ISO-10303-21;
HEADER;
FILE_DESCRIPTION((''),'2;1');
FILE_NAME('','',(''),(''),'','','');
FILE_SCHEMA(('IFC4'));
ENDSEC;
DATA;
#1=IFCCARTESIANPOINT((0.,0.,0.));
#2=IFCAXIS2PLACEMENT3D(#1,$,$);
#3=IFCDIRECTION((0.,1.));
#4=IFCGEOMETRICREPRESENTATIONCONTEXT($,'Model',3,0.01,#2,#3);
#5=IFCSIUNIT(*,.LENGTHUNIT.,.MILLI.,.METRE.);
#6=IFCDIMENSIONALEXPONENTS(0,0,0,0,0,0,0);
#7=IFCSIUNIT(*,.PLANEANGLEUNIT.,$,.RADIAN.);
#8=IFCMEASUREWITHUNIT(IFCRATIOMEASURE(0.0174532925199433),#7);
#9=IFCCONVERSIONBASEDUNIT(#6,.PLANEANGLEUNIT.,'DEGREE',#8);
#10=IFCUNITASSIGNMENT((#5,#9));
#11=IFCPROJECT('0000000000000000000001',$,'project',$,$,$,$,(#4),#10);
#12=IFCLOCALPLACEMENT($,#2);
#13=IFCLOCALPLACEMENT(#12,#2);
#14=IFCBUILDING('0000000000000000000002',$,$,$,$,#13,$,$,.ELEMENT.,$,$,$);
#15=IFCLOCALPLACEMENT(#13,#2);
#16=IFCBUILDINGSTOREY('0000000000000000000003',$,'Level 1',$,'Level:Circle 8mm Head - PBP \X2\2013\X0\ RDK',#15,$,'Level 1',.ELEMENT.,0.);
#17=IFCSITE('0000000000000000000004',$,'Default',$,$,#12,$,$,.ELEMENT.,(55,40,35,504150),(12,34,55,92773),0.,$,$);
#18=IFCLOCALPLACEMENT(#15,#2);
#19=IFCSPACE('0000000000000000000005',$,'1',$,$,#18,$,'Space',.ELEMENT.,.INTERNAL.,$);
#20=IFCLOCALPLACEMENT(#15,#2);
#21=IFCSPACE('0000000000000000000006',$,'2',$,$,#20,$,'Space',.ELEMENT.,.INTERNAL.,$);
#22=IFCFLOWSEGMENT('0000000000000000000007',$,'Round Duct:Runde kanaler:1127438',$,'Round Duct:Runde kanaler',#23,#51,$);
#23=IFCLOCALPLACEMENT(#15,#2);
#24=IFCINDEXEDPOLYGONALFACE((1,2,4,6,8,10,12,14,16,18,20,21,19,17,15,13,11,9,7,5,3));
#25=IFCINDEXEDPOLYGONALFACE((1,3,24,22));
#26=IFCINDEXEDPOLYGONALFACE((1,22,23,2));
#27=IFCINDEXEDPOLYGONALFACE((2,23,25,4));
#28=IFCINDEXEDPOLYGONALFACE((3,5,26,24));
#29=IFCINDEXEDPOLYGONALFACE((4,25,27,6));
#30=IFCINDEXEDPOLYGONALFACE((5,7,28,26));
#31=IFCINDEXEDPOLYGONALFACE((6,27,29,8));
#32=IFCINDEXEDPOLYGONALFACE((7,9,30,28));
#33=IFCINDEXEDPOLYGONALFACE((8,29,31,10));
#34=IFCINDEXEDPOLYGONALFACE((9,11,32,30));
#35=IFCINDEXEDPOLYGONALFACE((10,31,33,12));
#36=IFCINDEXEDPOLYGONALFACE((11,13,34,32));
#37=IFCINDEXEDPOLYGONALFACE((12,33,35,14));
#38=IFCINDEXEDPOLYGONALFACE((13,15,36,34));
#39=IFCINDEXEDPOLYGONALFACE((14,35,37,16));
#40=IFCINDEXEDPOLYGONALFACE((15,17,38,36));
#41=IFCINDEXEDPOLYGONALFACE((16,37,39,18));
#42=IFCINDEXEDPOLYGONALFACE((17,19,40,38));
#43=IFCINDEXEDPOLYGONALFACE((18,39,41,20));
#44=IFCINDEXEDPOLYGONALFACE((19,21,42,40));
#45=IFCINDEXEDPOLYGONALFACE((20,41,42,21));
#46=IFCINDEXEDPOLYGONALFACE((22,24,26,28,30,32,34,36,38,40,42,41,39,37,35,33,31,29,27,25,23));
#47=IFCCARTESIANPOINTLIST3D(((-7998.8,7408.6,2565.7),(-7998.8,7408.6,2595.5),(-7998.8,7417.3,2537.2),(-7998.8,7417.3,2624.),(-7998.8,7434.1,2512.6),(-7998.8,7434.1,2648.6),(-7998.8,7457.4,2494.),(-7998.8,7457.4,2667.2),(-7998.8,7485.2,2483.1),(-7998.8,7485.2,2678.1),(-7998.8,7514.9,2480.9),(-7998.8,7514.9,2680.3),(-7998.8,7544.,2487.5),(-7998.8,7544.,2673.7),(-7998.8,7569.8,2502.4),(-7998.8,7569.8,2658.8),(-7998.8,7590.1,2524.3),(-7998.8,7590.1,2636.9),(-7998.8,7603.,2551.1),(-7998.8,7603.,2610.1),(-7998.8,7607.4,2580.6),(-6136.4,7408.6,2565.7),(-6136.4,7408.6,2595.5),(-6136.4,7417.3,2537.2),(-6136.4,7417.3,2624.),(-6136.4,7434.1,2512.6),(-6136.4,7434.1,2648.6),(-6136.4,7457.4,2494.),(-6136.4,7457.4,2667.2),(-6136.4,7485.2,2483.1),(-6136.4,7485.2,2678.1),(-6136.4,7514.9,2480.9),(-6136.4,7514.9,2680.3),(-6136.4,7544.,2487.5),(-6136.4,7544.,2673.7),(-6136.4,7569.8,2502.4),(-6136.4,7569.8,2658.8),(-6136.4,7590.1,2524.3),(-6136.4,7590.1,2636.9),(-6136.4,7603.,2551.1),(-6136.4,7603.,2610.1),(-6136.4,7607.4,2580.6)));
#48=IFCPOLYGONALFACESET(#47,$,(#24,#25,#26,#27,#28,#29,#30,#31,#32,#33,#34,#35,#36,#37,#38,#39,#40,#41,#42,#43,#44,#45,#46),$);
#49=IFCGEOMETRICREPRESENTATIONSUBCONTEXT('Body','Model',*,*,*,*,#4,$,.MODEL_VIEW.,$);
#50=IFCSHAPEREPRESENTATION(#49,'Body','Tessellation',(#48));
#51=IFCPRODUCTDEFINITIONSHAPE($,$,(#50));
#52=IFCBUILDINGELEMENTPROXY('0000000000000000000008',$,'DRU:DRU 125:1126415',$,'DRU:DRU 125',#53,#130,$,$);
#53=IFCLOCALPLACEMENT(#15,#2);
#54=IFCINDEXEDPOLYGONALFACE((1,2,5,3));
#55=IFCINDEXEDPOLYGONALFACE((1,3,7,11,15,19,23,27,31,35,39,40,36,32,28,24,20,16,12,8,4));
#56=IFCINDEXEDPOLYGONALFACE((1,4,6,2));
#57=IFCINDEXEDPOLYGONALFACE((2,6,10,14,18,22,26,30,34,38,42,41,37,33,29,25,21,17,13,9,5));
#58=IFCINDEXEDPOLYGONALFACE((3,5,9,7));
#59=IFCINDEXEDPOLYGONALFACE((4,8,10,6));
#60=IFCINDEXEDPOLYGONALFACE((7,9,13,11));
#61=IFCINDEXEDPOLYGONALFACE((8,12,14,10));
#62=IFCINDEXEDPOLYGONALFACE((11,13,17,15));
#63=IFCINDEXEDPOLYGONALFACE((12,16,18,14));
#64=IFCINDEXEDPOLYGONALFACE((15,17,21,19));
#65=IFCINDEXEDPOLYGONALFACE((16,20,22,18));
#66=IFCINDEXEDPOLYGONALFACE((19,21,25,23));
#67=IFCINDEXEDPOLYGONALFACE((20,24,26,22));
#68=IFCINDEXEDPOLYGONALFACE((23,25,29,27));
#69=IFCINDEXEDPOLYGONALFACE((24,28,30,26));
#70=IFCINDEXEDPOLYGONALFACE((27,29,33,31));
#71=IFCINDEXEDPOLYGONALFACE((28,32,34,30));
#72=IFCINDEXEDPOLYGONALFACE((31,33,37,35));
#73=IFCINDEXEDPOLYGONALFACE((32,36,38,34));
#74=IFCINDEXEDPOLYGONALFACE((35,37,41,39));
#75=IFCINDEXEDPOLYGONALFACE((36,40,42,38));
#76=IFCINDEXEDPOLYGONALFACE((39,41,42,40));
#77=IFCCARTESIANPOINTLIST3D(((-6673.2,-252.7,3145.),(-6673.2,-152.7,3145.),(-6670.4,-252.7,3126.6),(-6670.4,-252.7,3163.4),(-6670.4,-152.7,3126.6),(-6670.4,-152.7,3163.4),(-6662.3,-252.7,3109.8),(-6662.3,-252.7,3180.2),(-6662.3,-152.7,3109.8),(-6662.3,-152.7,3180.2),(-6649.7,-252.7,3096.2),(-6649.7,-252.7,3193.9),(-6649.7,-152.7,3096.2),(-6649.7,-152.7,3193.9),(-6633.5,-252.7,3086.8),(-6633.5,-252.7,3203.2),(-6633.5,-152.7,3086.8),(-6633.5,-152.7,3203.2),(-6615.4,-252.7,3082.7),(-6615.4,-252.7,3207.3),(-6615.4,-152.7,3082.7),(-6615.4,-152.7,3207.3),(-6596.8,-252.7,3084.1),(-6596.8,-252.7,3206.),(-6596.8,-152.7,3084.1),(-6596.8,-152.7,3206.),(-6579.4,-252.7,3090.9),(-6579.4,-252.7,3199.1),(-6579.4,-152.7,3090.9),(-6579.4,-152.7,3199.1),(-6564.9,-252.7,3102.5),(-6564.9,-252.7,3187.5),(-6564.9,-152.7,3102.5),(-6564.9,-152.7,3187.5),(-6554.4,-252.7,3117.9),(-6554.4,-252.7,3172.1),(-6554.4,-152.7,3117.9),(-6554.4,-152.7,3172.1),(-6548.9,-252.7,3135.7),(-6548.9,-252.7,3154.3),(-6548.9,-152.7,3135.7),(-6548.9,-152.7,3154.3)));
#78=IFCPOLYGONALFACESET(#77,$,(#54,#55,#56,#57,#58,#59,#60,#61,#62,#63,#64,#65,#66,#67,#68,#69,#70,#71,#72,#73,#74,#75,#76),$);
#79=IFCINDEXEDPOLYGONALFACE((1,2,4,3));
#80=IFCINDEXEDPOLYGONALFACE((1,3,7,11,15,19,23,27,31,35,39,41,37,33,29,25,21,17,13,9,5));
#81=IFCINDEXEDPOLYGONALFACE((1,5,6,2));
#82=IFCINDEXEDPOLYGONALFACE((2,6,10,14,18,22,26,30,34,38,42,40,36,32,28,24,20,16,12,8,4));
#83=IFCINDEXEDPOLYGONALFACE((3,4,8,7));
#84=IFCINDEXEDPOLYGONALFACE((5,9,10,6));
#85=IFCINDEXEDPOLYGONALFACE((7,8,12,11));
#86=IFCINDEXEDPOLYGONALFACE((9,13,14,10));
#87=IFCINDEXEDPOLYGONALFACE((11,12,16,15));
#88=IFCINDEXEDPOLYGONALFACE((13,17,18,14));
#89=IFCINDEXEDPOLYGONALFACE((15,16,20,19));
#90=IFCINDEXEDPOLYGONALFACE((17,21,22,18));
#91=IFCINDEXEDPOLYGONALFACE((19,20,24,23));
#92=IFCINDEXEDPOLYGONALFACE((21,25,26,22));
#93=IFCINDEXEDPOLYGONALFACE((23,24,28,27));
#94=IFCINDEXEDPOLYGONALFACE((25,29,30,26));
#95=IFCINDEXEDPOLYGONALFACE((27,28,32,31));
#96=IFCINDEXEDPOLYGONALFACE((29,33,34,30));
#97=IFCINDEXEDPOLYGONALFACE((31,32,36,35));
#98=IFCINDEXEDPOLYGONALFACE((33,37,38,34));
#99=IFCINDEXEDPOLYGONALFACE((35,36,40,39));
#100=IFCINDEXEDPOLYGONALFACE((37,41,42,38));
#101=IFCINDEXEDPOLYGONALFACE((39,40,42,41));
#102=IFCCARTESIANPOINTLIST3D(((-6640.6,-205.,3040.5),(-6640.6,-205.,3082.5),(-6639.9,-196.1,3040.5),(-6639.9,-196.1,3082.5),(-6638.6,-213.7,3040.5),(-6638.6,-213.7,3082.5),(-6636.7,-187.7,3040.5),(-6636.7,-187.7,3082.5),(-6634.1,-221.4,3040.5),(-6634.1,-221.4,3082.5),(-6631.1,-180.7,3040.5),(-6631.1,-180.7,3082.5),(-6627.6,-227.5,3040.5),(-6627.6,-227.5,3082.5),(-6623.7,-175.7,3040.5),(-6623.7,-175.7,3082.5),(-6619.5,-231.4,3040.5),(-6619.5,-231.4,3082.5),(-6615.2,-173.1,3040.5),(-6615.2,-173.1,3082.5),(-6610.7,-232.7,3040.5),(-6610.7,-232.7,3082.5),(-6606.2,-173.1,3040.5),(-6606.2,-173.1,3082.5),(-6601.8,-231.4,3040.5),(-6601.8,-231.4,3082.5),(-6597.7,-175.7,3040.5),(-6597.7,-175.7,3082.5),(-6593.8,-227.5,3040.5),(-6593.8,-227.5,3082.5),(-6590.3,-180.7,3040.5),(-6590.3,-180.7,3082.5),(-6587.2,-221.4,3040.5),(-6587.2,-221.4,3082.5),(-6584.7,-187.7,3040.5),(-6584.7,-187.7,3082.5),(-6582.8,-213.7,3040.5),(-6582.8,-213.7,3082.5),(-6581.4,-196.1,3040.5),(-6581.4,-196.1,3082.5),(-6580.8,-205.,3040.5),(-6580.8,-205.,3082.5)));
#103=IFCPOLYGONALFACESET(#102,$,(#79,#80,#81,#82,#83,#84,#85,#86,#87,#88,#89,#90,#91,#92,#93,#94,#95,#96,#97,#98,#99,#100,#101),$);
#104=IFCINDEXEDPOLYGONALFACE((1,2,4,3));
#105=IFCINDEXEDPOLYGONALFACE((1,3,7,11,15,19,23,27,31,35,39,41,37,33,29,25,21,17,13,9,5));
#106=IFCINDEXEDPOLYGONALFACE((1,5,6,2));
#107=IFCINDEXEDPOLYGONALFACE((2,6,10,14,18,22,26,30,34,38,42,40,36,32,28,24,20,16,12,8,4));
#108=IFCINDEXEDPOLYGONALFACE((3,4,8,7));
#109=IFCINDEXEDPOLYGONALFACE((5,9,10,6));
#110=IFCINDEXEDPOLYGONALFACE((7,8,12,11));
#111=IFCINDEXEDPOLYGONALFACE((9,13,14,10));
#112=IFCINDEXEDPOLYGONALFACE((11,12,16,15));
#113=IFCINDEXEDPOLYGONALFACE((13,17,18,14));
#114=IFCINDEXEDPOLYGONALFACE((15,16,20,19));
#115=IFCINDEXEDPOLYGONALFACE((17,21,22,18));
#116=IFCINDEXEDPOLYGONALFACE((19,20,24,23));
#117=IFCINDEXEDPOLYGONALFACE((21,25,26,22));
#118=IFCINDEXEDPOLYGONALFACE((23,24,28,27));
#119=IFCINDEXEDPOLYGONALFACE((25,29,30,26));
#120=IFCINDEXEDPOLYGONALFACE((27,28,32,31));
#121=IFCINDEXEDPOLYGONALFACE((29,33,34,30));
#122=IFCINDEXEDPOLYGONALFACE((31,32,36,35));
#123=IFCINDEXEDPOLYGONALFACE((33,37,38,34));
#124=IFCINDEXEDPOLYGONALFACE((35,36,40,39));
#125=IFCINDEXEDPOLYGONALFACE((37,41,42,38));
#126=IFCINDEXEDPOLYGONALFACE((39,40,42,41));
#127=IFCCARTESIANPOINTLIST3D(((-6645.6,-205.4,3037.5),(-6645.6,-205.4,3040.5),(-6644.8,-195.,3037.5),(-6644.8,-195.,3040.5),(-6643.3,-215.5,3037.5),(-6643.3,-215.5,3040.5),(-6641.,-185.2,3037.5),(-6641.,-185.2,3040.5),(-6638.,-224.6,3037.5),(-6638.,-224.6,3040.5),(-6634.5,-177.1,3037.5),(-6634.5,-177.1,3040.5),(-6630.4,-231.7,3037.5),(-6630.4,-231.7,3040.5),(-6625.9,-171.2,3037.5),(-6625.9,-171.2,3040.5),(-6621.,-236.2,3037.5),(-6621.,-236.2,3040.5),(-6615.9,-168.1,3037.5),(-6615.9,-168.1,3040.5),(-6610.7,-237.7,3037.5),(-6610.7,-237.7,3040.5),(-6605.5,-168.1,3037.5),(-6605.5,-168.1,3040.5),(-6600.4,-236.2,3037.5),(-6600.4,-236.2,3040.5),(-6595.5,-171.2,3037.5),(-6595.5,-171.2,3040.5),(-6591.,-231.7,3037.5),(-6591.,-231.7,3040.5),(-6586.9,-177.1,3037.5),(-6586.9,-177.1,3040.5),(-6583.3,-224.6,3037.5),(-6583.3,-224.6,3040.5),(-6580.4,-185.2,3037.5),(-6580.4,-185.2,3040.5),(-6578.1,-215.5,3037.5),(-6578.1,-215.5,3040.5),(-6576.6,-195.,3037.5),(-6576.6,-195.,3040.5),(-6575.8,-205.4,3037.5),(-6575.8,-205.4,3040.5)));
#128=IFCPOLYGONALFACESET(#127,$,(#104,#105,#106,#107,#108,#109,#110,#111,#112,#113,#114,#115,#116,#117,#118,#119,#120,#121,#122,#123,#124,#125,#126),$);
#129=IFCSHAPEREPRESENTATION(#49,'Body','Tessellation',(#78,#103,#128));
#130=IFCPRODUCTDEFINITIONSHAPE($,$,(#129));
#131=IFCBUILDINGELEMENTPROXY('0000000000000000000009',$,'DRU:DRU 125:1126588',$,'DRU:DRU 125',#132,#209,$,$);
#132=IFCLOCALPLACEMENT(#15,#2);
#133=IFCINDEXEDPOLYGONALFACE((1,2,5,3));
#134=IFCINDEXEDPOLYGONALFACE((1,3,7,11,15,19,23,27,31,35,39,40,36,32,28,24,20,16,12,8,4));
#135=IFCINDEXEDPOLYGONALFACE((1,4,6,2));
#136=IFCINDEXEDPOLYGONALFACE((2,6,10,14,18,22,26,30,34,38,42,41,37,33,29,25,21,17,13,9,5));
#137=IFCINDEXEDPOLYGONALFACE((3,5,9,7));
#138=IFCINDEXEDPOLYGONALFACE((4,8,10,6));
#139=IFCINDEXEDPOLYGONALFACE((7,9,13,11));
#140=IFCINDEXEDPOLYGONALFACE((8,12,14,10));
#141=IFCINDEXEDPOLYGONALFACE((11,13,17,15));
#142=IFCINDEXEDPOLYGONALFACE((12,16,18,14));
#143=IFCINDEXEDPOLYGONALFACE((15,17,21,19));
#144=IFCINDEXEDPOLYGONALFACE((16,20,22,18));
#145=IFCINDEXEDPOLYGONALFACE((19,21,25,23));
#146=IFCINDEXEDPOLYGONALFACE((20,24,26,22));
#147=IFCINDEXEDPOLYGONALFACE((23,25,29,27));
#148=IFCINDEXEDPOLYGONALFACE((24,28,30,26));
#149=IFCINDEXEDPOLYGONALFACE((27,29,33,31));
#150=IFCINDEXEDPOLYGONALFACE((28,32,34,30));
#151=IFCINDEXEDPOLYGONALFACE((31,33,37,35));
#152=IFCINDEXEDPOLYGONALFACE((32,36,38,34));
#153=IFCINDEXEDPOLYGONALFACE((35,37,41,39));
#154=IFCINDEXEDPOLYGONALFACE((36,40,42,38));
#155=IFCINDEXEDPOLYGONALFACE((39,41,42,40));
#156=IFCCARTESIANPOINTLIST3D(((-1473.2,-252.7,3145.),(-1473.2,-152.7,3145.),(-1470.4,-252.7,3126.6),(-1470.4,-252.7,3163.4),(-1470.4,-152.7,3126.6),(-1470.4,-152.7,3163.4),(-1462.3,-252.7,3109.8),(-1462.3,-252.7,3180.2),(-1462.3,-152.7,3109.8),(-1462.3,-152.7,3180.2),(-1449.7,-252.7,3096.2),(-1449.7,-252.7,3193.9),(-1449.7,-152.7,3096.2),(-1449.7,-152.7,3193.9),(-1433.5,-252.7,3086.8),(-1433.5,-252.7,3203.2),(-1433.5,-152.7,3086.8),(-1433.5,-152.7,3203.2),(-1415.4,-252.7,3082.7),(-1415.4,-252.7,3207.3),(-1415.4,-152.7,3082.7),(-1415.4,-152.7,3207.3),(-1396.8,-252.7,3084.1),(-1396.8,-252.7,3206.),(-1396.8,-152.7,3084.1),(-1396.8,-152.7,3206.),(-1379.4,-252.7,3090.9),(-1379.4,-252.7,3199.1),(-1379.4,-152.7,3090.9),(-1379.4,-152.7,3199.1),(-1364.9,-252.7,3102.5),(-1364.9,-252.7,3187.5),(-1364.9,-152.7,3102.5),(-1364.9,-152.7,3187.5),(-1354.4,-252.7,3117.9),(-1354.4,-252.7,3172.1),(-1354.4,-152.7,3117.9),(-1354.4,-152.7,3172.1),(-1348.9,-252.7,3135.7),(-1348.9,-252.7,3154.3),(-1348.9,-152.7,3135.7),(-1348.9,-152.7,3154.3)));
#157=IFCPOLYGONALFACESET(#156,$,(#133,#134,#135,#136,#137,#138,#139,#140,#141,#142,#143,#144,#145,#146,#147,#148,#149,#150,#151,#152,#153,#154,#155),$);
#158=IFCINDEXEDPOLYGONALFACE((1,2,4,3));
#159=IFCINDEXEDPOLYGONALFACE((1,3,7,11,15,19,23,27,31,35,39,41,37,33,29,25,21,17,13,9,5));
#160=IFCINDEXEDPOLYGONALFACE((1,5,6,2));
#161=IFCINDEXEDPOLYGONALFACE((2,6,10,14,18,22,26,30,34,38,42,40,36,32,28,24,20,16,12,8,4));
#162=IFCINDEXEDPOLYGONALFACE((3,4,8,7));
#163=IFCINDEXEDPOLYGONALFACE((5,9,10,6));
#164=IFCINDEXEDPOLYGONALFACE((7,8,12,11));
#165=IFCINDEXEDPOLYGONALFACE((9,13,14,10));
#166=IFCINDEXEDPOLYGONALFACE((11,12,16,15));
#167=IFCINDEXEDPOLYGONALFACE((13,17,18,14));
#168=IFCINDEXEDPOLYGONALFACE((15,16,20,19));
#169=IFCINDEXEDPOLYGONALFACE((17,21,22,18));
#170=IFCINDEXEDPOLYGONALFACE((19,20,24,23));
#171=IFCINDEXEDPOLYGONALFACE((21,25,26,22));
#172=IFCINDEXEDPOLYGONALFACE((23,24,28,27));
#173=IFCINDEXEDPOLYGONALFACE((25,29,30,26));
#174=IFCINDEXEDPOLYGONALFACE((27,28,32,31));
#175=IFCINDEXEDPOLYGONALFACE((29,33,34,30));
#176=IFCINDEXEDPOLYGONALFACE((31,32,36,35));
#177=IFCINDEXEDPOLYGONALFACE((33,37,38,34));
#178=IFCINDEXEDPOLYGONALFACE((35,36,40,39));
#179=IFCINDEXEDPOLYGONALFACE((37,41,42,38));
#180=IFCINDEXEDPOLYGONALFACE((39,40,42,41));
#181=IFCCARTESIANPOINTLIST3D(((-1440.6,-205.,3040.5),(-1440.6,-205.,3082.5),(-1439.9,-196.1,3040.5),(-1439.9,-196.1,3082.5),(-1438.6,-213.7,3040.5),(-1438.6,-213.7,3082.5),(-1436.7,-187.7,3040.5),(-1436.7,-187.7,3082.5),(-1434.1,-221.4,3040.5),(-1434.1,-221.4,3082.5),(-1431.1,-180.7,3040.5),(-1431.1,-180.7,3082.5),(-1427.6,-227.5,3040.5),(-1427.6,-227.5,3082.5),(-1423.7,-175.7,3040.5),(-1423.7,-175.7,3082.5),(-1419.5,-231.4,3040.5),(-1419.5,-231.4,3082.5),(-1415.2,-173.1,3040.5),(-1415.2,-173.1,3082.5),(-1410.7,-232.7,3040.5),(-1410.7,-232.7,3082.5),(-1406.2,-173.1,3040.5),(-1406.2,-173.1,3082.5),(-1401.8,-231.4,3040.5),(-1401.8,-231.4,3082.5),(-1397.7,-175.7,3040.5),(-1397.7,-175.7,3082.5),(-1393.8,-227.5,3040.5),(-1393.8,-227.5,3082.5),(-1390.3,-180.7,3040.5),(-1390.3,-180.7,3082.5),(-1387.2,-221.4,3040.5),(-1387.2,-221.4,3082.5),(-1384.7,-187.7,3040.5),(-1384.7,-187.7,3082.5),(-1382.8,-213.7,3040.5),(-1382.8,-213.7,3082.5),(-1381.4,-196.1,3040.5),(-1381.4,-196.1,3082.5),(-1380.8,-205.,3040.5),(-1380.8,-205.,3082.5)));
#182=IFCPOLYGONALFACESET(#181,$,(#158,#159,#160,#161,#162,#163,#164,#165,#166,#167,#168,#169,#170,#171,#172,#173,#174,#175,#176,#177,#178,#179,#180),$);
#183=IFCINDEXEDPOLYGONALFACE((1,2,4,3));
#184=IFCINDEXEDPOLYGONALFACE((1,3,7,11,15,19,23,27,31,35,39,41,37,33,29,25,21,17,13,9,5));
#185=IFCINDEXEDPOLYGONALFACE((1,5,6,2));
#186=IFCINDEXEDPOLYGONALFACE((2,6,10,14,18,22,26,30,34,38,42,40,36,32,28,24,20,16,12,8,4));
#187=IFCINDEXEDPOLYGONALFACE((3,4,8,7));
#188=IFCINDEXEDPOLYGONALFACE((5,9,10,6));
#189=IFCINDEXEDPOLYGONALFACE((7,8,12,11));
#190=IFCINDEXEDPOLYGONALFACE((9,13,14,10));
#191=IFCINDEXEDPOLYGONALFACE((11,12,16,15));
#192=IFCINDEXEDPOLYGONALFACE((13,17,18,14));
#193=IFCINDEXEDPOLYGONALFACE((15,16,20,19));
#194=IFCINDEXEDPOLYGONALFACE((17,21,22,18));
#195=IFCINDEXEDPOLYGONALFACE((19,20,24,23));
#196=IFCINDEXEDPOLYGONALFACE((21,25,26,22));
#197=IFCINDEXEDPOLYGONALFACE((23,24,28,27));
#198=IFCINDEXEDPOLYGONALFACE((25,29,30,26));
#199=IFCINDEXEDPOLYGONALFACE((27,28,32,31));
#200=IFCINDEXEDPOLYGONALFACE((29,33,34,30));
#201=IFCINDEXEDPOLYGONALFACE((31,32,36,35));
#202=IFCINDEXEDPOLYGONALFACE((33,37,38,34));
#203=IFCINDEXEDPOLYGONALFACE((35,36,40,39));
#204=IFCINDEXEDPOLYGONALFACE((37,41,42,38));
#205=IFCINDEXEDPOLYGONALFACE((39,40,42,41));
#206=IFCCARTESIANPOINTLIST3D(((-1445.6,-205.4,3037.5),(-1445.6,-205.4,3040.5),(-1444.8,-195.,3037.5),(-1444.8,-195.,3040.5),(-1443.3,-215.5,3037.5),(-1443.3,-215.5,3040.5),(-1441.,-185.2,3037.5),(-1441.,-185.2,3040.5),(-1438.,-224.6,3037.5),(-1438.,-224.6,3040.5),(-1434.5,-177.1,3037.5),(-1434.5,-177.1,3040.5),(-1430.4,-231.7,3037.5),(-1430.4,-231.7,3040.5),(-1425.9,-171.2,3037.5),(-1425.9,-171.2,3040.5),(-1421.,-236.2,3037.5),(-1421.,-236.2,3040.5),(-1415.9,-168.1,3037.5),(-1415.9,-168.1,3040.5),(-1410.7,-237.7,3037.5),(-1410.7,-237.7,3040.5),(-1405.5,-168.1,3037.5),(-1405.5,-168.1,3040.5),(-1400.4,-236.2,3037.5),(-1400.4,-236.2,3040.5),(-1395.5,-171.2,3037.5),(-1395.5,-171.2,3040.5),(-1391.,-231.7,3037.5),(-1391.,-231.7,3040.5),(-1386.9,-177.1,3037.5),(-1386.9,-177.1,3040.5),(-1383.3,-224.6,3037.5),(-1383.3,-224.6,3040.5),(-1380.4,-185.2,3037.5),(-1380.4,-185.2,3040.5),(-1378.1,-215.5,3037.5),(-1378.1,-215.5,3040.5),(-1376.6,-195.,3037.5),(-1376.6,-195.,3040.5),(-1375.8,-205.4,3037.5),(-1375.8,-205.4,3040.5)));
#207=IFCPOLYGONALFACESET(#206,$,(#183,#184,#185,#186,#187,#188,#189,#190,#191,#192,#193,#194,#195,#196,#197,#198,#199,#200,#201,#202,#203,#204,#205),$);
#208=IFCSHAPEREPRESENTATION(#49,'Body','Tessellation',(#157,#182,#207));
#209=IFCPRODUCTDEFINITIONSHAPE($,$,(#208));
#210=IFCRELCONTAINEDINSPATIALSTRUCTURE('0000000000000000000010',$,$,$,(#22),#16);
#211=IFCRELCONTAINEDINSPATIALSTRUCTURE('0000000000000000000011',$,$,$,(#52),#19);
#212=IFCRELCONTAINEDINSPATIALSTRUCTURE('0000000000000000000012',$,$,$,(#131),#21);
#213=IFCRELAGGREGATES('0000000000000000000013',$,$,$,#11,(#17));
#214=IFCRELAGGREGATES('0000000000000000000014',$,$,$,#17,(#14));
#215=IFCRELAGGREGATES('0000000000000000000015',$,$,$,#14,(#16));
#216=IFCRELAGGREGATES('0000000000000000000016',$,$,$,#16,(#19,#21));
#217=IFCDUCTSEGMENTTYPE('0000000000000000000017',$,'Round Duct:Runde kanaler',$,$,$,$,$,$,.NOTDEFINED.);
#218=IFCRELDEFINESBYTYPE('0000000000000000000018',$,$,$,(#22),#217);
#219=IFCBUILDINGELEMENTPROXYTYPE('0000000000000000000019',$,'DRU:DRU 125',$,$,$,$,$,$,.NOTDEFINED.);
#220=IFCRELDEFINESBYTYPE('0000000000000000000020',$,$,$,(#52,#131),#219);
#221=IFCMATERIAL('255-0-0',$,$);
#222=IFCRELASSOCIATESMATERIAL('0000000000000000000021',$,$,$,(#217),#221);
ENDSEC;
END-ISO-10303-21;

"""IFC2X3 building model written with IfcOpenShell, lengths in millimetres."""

from ifc_helpers import new_model, entity, si_unit, converted_unit, direction, frame, frame_2d, origin, place, context, subcontext, project, spatial, circle, extrude, source, transform, mapped, material, type_object, type_shapes, element, save


model = new_model("IFC2X3")

# Units and contexts
model_context = context("Model", 3, precision=0.01, world=origin(), true_north=direction((0.0, 1.0)))
body_context = subcontext(model_context, "Body", "Model", "MODEL_VIEW")
ifc_project = project(units=[si_unit("LENGTHUNIT", "METRE", prefix="MILLI"), converted_unit("PLANEANGLEUNIT", "DEGREE", entity("IfcRatioMeasure", 0.0174532925199433), si_unit("PLANEANGLEUNIT", "RADIAN"), dimensions=[0, 0, 0, 0, 0, 0, 0])], contexts=[model_context])

# Site, building, storey
site_placement = place(None, origin())
site = spatial("IfcSite", under=ifc_project, at=site_placement, Name="Default", CompositionType="ELEMENT", RefLatitude=(55, 40, 35, 504150), RefLongitude=(12, 34, 55, 92773), RefElevation=0.0)
building_placement = place(site_placement, origin())
building = spatial("IfcBuilding", under=site, at=building_placement, CompositionType="ELEMENT")
storey_placement = place(building_placement, origin())
storey = spatial("IfcBuildingStorey", under=building, at=storey_placement, Name="Level 1", ObjectType="Level:Circle 8mm Head - PBP – RDK", LongName="Level 1", CompositionType="ELEMENT", Elevation=0.0)

# Flow segment
ifc_material_1 = material(Name="255-0-0")
duct_segment_type = type_object("IfcDuctSegmentType", Name="Round Duct:Runde kanaler", PredefinedType="NOTDEFINED", material=ifc_material_1)
flow_segment_1_placement = place(storey_placement, origin())
element("IfcFlowSegment", 1, at=flow_segment_1_placement, inside=storey, type_object=duct_segment_type, Name="Round Duct:Runde kanaler:1127438", ObjectType="Round Duct:Runde kanaler", context=body_context, shape_type="SweptSolid", body=[
    extrude(circle(Radius=100.0, at=frame_2d((0.0, 0.0), x_axis=(1.0, 0.0))), frame((-7998.8, 7507.4, 2580.6), z_axis=(1.0, 0.0, 0.0), x_axis=(0.0, 1.0, 0.0)), (0.0, 0.0, 1.0), 1862.4),
])

# Shared definitions
space_1_placement = place(storey_placement, origin())
space_1 = spatial("IfcSpace", under=storey, at=space_1_placement, Name="1", LongName="Space", CompositionType="ELEMENT", InteriorOrExteriorSpace="INTERNAL")

# Building element proxy
building_element_proxy_type_1 = type_object("IfcBuildingElementProxyType", Name="DRU:DRU 125", PredefinedType="NOTDEFINED")
shared_shape_1 = source(origin(), body_context, "Body", "SweptSolid", [
    extrude(circle(Radius=62.5, at=frame_2d((0.0, 0.0), x_axis=(1.0, 0.0))), frame((-50.0, 0.0, 0.0), z_axis=(1.0, 0.0, 0.0), x_axis=(0.0, 1.0, 0.0)), (0.0, 0.0, 1.0), 100.0),
    extrude(circle(Radius=30.0, at=frame_2d((0.0, 0.0), x_axis=(1.0, 0.0))), frame((0.0, 0.0, 62.5)), (0.0, 0.0, 1.0), 42.0),
    extrude(circle(Radius=35.0, at=frame_2d((0.0, 0.0), x_axis=(1.0, 0.0))), frame((0.0, 0.0, 104.5)), (0.0, 0.0, 1.0), 3.0),
])
type_shapes(building_element_proxy_type_1, [shared_shape_1])
proxy_1_placement = place(space_1_placement, frame((-6610.7, -202.7, 3145.0), z_axis=(0.0, 0.0, -1.0), x_axis=(0.0, -1.0, 0.0)))
element("IfcBuildingElementProxy", 2, at=proxy_1_placement, inside=space_1, type_object=building_element_proxy_type_1, Name="DRU:DRU 125:1126415", ObjectType="DRU:DRU 125", context=body_context, shape_type="MappedRepresentation", body=[
    mapped(shared_shape_1, transform((0.0, 0.0, 0.0), scale=1.0)),
])

# Shared definitions
space_2_placement = place(storey_placement, origin())
space_2 = spatial("IfcSpace", under=storey, at=space_2_placement, Name="2", LongName="Space", CompositionType="ELEMENT", InteriorOrExteriorSpace="INTERNAL")

# Building element proxy
proxy_2_placement = place(space_2_placement, frame((-1410.7, -202.7, 3145.0), z_axis=(0.0, 0.0, -1.0), x_axis=(0.0, -1.0, 0.0)))
element("IfcBuildingElementProxy", 3, at=proxy_2_placement, inside=space_2, type_object=building_element_proxy_type_1, Name="DRU:DRU 125:1126588", ObjectType="DRU:DRU 125", context=body_context, shape_type="MappedRepresentation", body=[
    mapped(shared_shape_1, transform((0.0, 0.0, 0.0), scale=1.0)),
])

save(model, "model.ifc")
